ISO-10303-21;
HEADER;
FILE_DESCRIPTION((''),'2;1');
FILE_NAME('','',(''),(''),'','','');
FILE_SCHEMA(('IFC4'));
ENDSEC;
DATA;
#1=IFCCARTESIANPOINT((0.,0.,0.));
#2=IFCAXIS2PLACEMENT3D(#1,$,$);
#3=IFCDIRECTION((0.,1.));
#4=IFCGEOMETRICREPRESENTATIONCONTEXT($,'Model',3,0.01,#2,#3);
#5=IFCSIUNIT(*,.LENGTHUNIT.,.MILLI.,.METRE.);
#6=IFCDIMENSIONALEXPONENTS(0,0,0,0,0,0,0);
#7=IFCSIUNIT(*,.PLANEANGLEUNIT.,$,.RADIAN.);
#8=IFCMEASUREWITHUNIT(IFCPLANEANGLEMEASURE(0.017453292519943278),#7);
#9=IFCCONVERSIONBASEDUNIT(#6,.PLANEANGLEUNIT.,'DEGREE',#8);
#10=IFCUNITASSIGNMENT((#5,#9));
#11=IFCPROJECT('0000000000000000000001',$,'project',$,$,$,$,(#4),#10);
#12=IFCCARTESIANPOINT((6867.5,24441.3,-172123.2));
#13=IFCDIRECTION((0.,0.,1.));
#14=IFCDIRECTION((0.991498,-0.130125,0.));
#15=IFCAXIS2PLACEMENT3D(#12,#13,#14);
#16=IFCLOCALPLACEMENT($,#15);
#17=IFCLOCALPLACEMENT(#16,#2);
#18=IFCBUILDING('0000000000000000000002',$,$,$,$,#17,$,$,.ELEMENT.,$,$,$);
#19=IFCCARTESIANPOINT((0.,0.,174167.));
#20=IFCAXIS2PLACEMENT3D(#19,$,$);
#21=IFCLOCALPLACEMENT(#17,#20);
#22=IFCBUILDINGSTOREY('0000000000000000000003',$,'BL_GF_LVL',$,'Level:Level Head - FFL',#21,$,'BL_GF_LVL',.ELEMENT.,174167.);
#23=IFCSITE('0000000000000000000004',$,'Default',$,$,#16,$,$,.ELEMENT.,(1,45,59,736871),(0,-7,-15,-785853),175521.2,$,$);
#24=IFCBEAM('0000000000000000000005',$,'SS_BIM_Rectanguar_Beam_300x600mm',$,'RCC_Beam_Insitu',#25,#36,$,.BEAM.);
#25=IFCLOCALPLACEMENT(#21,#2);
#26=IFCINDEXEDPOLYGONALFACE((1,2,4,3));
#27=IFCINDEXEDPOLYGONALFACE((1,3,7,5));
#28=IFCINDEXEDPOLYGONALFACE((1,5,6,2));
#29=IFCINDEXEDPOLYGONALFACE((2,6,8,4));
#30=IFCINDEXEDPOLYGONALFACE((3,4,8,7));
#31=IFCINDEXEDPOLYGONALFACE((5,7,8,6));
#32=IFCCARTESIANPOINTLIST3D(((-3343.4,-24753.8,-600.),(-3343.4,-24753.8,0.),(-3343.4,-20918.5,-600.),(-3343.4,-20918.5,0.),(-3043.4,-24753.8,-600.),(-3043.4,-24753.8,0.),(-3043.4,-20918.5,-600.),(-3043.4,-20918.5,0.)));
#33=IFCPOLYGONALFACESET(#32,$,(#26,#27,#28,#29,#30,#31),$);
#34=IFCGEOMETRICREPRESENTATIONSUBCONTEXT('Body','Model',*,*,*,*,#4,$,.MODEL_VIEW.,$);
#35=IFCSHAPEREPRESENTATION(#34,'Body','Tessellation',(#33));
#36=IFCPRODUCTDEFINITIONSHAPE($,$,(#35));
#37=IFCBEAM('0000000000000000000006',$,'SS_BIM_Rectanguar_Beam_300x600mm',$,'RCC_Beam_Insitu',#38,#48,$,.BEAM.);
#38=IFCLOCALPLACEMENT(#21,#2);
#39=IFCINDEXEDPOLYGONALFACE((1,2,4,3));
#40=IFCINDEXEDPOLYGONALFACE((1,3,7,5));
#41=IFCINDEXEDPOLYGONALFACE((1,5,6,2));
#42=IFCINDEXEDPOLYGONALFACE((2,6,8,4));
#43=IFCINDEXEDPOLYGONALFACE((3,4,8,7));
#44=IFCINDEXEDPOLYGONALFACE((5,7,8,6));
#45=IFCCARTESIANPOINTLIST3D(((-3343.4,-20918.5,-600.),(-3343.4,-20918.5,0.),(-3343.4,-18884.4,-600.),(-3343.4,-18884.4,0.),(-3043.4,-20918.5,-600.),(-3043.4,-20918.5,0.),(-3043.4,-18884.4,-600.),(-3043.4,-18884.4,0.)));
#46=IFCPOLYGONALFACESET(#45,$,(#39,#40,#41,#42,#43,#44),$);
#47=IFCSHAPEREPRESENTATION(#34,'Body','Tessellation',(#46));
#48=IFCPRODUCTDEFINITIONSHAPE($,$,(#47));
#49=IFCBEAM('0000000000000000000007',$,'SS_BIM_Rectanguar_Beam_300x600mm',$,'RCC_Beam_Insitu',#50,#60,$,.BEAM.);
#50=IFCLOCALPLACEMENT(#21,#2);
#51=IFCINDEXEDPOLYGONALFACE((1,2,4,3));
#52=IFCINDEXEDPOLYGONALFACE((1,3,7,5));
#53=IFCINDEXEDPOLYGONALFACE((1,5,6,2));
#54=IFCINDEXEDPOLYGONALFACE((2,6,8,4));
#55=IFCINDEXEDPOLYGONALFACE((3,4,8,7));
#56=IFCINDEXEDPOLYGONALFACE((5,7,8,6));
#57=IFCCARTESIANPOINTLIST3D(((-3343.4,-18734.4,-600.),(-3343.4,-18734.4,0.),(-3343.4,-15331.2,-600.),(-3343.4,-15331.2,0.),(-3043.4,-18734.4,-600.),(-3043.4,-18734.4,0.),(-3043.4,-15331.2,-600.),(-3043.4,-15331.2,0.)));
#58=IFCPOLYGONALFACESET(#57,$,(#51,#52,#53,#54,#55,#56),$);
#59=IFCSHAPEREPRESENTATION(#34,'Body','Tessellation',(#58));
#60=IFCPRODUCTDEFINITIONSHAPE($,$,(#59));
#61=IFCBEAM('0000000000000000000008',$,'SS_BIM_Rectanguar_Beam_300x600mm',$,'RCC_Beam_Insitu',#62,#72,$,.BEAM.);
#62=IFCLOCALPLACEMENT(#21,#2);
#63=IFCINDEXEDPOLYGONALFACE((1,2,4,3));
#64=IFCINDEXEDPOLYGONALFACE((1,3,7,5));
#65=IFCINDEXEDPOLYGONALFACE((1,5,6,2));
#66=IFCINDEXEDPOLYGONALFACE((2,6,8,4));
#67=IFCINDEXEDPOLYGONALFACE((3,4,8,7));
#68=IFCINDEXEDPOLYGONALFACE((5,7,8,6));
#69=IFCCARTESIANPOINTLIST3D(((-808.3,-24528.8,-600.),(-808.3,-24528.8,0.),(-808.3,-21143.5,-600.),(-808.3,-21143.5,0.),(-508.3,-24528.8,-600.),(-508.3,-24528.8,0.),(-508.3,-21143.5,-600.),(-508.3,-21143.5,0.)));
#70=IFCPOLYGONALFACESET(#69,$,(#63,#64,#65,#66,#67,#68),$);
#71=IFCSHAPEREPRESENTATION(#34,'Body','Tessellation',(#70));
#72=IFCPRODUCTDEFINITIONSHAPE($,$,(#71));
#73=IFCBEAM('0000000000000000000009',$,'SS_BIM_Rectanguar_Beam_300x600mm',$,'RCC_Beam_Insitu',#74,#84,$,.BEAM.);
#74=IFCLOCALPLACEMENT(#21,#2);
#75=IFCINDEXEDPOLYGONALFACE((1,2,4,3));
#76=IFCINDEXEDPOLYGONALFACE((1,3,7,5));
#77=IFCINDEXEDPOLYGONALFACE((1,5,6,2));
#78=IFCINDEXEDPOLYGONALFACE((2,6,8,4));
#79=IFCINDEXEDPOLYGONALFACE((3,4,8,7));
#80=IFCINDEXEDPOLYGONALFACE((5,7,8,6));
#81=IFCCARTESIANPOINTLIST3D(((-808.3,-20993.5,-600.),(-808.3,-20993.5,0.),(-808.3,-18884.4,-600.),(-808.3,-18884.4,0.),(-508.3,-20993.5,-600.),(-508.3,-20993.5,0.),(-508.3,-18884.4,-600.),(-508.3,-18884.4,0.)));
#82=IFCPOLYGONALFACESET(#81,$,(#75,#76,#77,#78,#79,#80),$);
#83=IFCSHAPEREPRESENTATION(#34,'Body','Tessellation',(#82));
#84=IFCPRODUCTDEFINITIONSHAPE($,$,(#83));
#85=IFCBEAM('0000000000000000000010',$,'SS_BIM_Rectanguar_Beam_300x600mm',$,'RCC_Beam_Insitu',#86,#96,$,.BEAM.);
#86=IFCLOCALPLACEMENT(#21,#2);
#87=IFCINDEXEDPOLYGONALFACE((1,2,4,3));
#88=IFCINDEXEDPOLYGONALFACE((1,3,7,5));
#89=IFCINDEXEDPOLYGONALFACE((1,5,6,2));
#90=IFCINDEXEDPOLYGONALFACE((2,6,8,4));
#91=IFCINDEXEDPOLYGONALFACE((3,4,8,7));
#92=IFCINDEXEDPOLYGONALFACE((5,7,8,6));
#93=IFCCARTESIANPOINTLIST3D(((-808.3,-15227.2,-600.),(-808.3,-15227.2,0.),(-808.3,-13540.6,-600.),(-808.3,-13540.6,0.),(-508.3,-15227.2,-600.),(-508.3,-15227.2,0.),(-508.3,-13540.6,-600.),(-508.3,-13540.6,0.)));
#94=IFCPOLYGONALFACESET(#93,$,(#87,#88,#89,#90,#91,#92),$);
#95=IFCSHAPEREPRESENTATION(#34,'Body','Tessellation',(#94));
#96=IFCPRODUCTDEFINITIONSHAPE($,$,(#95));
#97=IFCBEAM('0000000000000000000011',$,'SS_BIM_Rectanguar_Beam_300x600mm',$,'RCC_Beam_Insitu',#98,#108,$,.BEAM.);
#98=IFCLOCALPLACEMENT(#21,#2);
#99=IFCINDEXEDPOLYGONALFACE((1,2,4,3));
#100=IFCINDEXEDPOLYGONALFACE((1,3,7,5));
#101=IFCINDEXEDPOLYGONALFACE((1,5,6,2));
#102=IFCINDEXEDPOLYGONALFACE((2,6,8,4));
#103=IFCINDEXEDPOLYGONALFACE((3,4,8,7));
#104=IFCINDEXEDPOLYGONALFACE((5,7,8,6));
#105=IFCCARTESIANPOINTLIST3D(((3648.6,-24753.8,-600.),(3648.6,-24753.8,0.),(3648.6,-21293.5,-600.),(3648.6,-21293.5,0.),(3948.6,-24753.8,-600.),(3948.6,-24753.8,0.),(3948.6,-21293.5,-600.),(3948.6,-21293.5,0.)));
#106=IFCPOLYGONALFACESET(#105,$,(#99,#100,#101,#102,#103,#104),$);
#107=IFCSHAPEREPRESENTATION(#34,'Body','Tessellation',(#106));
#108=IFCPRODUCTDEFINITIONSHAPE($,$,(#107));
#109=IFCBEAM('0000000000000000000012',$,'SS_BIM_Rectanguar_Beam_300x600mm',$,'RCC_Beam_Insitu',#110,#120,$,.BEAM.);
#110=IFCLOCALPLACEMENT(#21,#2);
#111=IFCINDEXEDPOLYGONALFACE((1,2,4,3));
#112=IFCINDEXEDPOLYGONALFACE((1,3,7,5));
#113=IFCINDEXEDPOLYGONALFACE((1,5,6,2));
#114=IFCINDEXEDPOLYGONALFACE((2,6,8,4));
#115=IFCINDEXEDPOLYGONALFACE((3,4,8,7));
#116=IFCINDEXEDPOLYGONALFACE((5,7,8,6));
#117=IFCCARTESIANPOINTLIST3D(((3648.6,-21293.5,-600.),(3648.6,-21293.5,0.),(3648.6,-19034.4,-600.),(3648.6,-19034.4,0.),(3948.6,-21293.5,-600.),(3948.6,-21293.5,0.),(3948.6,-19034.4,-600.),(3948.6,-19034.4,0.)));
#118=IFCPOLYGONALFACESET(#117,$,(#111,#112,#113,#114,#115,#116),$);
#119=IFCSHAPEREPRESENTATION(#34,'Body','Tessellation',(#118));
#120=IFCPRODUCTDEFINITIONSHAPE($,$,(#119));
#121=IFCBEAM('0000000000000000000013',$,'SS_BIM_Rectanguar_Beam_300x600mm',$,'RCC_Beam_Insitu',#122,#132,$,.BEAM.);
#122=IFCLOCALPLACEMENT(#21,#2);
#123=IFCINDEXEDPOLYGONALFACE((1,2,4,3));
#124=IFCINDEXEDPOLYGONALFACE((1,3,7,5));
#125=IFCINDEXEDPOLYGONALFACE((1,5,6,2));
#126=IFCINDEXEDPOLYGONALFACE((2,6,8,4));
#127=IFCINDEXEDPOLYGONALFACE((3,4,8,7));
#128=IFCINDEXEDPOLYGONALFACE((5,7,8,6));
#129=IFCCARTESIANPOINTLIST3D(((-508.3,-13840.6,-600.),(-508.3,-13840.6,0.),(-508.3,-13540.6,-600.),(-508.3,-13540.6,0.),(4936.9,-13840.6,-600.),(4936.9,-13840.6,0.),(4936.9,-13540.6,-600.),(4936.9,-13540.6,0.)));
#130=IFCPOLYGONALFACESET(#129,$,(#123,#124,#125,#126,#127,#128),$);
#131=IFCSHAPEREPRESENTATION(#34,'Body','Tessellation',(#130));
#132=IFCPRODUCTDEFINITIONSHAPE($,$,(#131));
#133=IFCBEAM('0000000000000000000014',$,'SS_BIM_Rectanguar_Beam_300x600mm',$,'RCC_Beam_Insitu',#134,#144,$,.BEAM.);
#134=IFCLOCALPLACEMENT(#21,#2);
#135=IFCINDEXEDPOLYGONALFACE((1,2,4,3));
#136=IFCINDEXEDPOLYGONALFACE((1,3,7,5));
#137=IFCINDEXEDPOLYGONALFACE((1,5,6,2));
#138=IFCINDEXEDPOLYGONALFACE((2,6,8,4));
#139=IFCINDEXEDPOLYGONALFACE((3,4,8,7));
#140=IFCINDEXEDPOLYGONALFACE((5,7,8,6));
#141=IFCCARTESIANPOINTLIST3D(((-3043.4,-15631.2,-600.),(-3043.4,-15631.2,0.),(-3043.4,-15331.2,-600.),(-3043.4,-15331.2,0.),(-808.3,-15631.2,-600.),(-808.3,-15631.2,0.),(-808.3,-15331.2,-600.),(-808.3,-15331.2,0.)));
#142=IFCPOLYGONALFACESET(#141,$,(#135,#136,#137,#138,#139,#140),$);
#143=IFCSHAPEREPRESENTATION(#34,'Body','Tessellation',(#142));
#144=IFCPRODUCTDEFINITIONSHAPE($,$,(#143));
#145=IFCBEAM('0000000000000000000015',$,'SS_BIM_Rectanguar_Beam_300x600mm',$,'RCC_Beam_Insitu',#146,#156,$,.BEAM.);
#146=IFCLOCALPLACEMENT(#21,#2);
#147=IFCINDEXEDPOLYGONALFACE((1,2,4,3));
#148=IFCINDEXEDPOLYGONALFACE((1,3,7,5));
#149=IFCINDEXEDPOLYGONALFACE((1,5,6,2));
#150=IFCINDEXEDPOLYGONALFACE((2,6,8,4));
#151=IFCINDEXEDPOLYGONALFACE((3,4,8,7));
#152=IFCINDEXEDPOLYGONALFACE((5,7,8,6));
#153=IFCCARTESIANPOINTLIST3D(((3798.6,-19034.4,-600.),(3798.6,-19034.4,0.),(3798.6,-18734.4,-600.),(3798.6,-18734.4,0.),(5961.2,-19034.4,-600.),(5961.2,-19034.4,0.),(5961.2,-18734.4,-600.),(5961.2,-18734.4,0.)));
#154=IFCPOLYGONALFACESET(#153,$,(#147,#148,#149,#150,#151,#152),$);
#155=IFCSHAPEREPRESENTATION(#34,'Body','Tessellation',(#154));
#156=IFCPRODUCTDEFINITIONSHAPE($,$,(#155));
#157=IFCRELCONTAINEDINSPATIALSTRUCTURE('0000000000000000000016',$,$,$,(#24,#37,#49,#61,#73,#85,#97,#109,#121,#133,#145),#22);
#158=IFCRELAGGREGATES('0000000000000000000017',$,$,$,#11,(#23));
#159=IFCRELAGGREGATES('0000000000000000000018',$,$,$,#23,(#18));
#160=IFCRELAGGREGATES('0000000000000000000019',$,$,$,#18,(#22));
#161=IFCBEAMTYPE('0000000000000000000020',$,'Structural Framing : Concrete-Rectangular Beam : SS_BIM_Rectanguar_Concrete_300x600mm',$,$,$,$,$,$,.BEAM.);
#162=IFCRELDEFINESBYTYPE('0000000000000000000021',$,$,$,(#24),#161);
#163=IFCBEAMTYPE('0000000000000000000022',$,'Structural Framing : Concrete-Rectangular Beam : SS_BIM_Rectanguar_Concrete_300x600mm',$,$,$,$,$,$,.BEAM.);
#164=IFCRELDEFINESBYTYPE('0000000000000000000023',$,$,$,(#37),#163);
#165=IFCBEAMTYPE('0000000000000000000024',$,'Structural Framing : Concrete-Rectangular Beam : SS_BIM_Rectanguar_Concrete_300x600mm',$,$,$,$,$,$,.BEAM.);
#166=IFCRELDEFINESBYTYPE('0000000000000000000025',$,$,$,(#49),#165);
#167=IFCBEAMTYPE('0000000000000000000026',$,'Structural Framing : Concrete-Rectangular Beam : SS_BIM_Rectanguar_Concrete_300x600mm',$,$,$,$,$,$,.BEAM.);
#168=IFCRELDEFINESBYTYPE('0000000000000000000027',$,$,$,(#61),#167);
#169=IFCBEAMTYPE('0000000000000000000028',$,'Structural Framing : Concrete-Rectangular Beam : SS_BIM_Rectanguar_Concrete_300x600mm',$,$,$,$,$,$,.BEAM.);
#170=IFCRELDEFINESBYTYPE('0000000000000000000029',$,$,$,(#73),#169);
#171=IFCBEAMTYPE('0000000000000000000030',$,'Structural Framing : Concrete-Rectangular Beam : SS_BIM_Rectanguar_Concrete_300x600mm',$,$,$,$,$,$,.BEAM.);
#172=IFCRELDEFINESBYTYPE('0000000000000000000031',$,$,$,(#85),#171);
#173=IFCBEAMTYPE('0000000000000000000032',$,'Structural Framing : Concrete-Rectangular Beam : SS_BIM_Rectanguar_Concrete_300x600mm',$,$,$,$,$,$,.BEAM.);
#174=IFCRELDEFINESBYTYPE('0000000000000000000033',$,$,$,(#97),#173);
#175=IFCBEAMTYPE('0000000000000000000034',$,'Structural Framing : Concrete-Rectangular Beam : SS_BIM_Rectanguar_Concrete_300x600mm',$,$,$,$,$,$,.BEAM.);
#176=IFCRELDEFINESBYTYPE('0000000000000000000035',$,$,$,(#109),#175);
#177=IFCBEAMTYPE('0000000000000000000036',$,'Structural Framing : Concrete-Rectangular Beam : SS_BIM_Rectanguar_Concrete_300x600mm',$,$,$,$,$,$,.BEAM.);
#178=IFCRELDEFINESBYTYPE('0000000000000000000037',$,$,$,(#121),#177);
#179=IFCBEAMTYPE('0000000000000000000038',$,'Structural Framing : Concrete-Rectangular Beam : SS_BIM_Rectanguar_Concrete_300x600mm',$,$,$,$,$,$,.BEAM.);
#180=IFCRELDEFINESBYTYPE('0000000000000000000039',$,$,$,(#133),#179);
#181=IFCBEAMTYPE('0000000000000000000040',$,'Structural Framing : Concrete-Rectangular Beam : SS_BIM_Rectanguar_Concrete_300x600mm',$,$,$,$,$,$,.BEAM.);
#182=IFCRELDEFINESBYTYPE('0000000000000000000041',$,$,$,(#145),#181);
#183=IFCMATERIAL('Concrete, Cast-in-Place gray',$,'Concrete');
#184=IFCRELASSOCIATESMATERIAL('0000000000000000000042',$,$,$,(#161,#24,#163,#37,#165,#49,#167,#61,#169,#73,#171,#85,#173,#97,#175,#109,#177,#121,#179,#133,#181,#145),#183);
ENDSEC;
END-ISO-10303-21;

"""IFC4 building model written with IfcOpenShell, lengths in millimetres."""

from ifc_helpers import new_model, entity, si_unit, converted_unit, direction, frame, origin, place, context, subcontext, project, spatial, indexed_curve, outline, extrude, source, transform, mapped, material, type_object, type_shapes, element, save


model = new_model("IFC4")

# Units and contexts
model_context = context("Model", 3, precision=0.01, world=origin(), true_north=direction((0.0, 1.0)))
body_context = subcontext(model_context, "Body", "Model", "MODEL_VIEW")
ifc_project = project(units=[si_unit("LENGTHUNIT", "METRE", prefix="MILLI"), converted_unit("PLANEANGLEUNIT", "DEGREE", entity("IfcPlaneAngleMeasure", 0.017453292519943278), si_unit("PLANEANGLEUNIT", "RADIAN"), dimensions=[0, 0, 0, 0, 0, 0, 0])], contexts=[model_context])

# Site, building, storey
site_placement = place(None, frame((6867.5, 24441.3, -172123.2), z_axis=(0.0, 0.0, 1.0), x_axis=(0.991498, -0.130125, 0.0)))
site = spatial("IfcSite", under=ifc_project, at=site_placement, Name="Default", CompositionType="ELEMENT", RefLatitude=(1, 45, 59, 736871), RefLongitude=(0, -7, -15, -785853), RefElevation=175521.2)
building_placement = place(site_placement, origin())
building = spatial("IfcBuilding", under=site, at=building_placement, CompositionType="ELEMENT")
storey_placement = place(building_placement, frame((0.0, 0.0, 174167.0)))
storey = spatial("IfcBuildingStorey", under=building, at=storey_placement, Name="BL_GF_LVL", ObjectType="Level:Level Head - FFL", LongName="BL_GF_LVL", CompositionType="ELEMENT", Elevation=174167.0)

# Shared definitions
ifc_material_1 = material(Name="Concrete, Cast-in-Place gray", Category="Concrete")

# Beams
beam_type_1 = type_object("IfcBeamType", Name="Structural Framing : Concrete-Rectangular Beam : SS_BIM_Rectanguar_Concrete_300x600mm", PredefinedType="BEAM", material=ifc_material_1)
shared_shape_1 = source(origin(), body_context, "Body", "SweptSolid", [
    extrude(outline(indexed_curve([(-150.0, -300.0), (150.0, -300.0), (150.0, 300.0), (-150.0, 300.0), (-150.0, -300.0)], self_intersect=False)), frame((-3193.4, -24753.8, 173867.0), z_axis=(0.0, 1.0, 0.0), x_axis=(-1.0, 0.0, 0.0)), (0.0, 0.0, 1.0), 3835.3),
])
type_shapes(beam_type_1, [shared_shape_1])
beam_1_placement = place(storey_placement, frame((0.0, 0.0, -174167.0)))
element("IfcBeam", 1, at=beam_1_placement, inside=storey, type_object=beam_type_1, material=ifc_material_1, Name="SS_BIM_Rectanguar_Beam_300x600mm", ObjectType="RCC_Beam_Insitu", PredefinedType="BEAM", context=body_context, shape_type="MappedRepresentation", body=[
    mapped(shared_shape_1, transform((0.0, 0.0, 0.0), scale=1.0)),
])
beam_type_2 = type_object("IfcBeamType", Name="Structural Framing : Concrete-Rectangular Beam : SS_BIM_Rectanguar_Concrete_300x600mm", PredefinedType="BEAM", material=ifc_material_1)
shared_shape_2 = source(origin(), body_context, "Body", "SweptSolid", [
    extrude(outline(indexed_curve([(-150.0, -300.0), (150.0, -300.0), (150.0, 300.0), (-150.0, 300.0), (-150.0, -300.0)], self_intersect=False)), frame((-3193.4, -20918.5, 173867.0), z_axis=(0.0, 1.0, 0.0), x_axis=(-1.0, 0.0, 0.0)), (0.0, 0.0, 1.0), 2034.1),
])
type_shapes(beam_type_2, [shared_shape_2])
beam_2_placement = place(storey_placement, frame((0.0, 0.0, -174167.0)))
element("IfcBeam", 2, at=beam_2_placement, inside=storey, type_object=beam_type_2, material=ifc_material_1, Name="SS_BIM_Rectanguar_Beam_300x600mm", ObjectType="RCC_Beam_Insitu", PredefinedType="BEAM", context=body_context, shape_type="MappedRepresentation", body=[
    mapped(shared_shape_2, transform((0.0, 0.0, 0.0), scale=1.0)),
])
beam_type_3 = type_object("IfcBeamType", Name="Structural Framing : Concrete-Rectangular Beam : SS_BIM_Rectanguar_Concrete_300x600mm", PredefinedType="BEAM", material=ifc_material_1)
shared_shape_3 = source(origin(), body_context, "Body", "SweptSolid", [
    extrude(outline(indexed_curve([(-150.0, -300.0), (150.0, -300.0), (150.0, 300.0), (-150.0, 300.0), (-150.0, -300.0)], self_intersect=False)), frame((-3193.4, -18734.4, 173867.0), z_axis=(0.0, 1.0, 0.0), x_axis=(-1.0, 0.0, 0.0)), (0.0, 0.0, 1.0), 3403.2),
])
type_shapes(beam_type_3, [shared_shape_3])
beam_3_placement = place(storey_placement, frame((0.0, 0.0, -174167.0)))
element("IfcBeam", 3, at=beam_3_placement, inside=storey, type_object=beam_type_3, material=ifc_material_1, Name="SS_BIM_Rectanguar_Beam_300x600mm", ObjectType="RCC_Beam_Insitu", PredefinedType="BEAM", context=body_context, shape_type="MappedRepresentation", body=[
    mapped(shared_shape_3, transform((0.0, 0.0, 0.0), scale=1.0)),
])
beam_type_4 = type_object("IfcBeamType", Name="Structural Framing : Concrete-Rectangular Beam : SS_BIM_Rectanguar_Concrete_300x600mm", PredefinedType="BEAM", material=ifc_material_1)
shared_shape_4 = source(origin(), body_context, "Body", "SweptSolid", [
    extrude(outline(indexed_curve([(-150.0, -300.0), (150.0, -300.0), (150.0, 300.0), (-150.0, 300.0), (-150.0, -300.0)], self_intersect=False)), frame((-658.3, -24528.8, 173867.0), z_axis=(0.0, 1.0, 0.0), x_axis=(-1.0, 0.0, 0.0)), (0.0, 0.0, 1.0), 3385.3),
])
type_shapes(beam_type_4, [shared_shape_4])
beam_4_placement = place(storey_placement, frame((0.0, 0.0, -174167.0)))
element("IfcBeam", 4, at=beam_4_placement, inside=storey, type_object=beam_type_4, material=ifc_material_1, Name="SS_BIM_Rectanguar_Beam_300x600mm", ObjectType="RCC_Beam_Insitu", PredefinedType="BEAM", context=body_context, shape_type="MappedRepresentation", body=[
    mapped(shared_shape_4, transform((0.0, 0.0, 0.0), scale=1.0)),
])
beam_type_5 = type_object("IfcBeamType", Name="Structural Framing : Concrete-Rectangular Beam : SS_BIM_Rectanguar_Concrete_300x600mm", PredefinedType="BEAM", material=ifc_material_1)
shared_shape_5 = source(origin(), body_context, "Body", "SweptSolid", [
    extrude(outline(indexed_curve([(-150.0, -300.0), (150.0, -300.0), (150.0, 300.0), (-150.0, 300.0), (-150.0, -300.0)], self_intersect=False)), frame((-658.3, -20993.5, 173867.0), z_axis=(0.0, 1.0, 0.0), x_axis=(-1.0, 0.0, 0.0)), (0.0, 0.0, 1.0), 2109.1),
])
type_shapes(beam_type_5, [shared_shape_5])
beam_5_placement = place(storey_placement, frame((0.0, 0.0, -174167.0)))
element("IfcBeam", 5, at=beam_5_placement, inside=storey, type_object=beam_type_5, material=ifc_material_1, Name="SS_BIM_Rectanguar_Beam_300x600mm", ObjectType="RCC_Beam_Insitu", PredefinedType="BEAM", context=body_context, shape_type="MappedRepresentation", body=[
    mapped(shared_shape_5, transform((0.0, 0.0, 0.0), scale=1.0)),
])
beam_type_6 = type_object("IfcBeamType", Name="Structural Framing : Concrete-Rectangular Beam : SS_BIM_Rectanguar_Concrete_300x600mm", PredefinedType="BEAM", material=ifc_material_1)
shared_shape_6 = source(origin(), body_context, "Body", "SweptSolid", [
    extrude(outline(indexed_curve([(-150.0, -300.0), (150.0, -300.0), (150.0, 300.0), (-150.0, 300.0), (-150.0, -300.0)], self_intersect=False)), frame((-658.3, -15227.2, 173867.0), z_axis=(0.0, 1.0, 0.0), x_axis=(-1.0, 0.0, 0.0)), (0.0, 0.0, 1.0), 1686.5),
])
type_shapes(beam_type_6, [shared_shape_6])
beam_6_placement = place(storey_placement, frame((0.0, 0.0, -174167.0)))
element("IfcBeam", 6, at=beam_6_placement, inside=storey, type_object=beam_type_6, material=ifc_material_1, Name="SS_BIM_Rectanguar_Beam_300x600mm", ObjectType="RCC_Beam_Insitu", PredefinedType="BEAM", context=body_context, shape_type="MappedRepresentation", body=[
    mapped(shared_shape_6, transform((0.0, 0.0, 0.0), scale=1.0)),
])
beam_type_7 = type_object("IfcBeamType", Name="Structural Framing : Concrete-Rectangular Beam : SS_BIM_Rectanguar_Concrete_300x600mm", PredefinedType="BEAM", material=ifc_material_1)
shared_shape_7 = source(origin(), body_context, "Body", "SweptSolid", [
    extrude(outline(indexed_curve([(-150.0, -300.0), (150.0, -300.0), (150.0, 300.0), (-150.0, 300.0), (-150.0, -300.0)], self_intersect=False)), frame((3798.6, -24753.8, 173867.0), z_axis=(0.0, 1.0, 0.0), x_axis=(-1.0, 0.0, 0.0)), (0.0, 0.0, 1.0), 3460.3),
])
type_shapes(beam_type_7, [shared_shape_7])
beam_7_placement = place(storey_placement, frame((0.0, 0.0, -174167.0)))
element("IfcBeam", 7, at=beam_7_placement, inside=storey, type_object=beam_type_7, material=ifc_material_1, Name="SS_BIM_Rectanguar_Beam_300x600mm", ObjectType="RCC_Beam_Insitu", PredefinedType="BEAM", context=body_context, shape_type="MappedRepresentation", body=[
    mapped(shared_shape_7, transform((0.0, 0.0, 0.0), scale=1.0)),
])
beam_type_8 = type_object("IfcBeamType", Name="Structural Framing : Concrete-Rectangular Beam : SS_BIM_Rectanguar_Concrete_300x600mm", PredefinedType="BEAM", material=ifc_material_1)
shared_shape_8 = source(origin(), body_context, "Body", "SweptSolid", [
    extrude(outline(indexed_curve([(-150.0, -300.0), (150.0, -300.0), (150.0, 300.0), (-150.0, 300.0), (-150.0, -300.0)], self_intersect=False)), frame((3798.6, -21293.5, 173867.0), z_axis=(0.0, 1.0, 0.0), x_axis=(-1.0, 0.0, 0.0)), (0.0, 0.0, 1.0), 2259.1),
])
type_shapes(beam_type_8, [shared_shape_8])
beam_8_placement = place(storey_placement, frame((0.0, 0.0, -174167.0)))
element("IfcBeam", 8, at=beam_8_placement, inside=storey, type_object=beam_type_8, material=ifc_material_1, Name="SS_BIM_Rectanguar_Beam_300x600mm", ObjectType="RCC_Beam_Insitu", PredefinedType="BEAM", context=body_context, shape_type="MappedRepresentation", body=[
    mapped(shared_shape_8, transform((0.0, 0.0, 0.0), scale=1.0)),
])
beam_type_9 = type_object("IfcBeamType", Name="Structural Framing : Concrete-Rectangular Beam : SS_BIM_Rectanguar_Concrete_300x600mm", PredefinedType="BEAM", material=ifc_material_1)
shared_shape_9 = source(origin(), body_context, "Body", "SweptSolid", [
    extrude(outline(indexed_curve([(-300.0, -150.0), (300.0, -150.0), (300.0, 150.0), (-300.0, 150.0), (-300.0, -150.0)], self_intersect=False)), frame((-508.3, -13690.6, 173867.0), z_axis=(1.0, 0.0, 0.0), x_axis=(0.0, 0.0, -1.0)), (0.0, 0.0, 1.0), 5445.2),
])
type_shapes(beam_type_9, [shared_shape_9])
beam_9_placement = place(storey_placement, frame((0.0, 0.0, -174167.0)))
element("IfcBeam", 9, at=beam_9_placement, inside=storey, type_object=beam_type_9, material=ifc_material_1, Name="SS_BIM_Rectanguar_Beam_300x600mm", ObjectType="RCC_Beam_Insitu", PredefinedType="BEAM", context=body_context, shape_type="MappedRepresentation", body=[
    mapped(shared_shape_9, transform((0.0, 0.0, 0.0), scale=1.0)),
])
beam_type_10 = type_object("IfcBeamType", Name="Structural Framing : Concrete-Rectangular Beam : SS_BIM_Rectanguar_Concrete_300x600mm", PredefinedType="BEAM", material=ifc_material_1)
shared_shape_10 = source(origin(), body_context, "Body", "SweptSolid", [
    extrude(outline(indexed_curve([(-300.0, -150.0), (300.0, -150.0), (300.0, 150.0), (-300.0, 150.0), (-300.0, -150.0)], self_intersect=False)), frame((-3043.4, -15481.2, 173867.0), z_axis=(1.0, 0.0, 0.0), x_axis=(0.0, 0.0, -1.0)), (0.0, 0.0, 1.0), 2235.1),
])
type_shapes(beam_type_10, [shared_shape_10])
beam_10_placement = place(storey_placement, frame((0.0, 0.0, -174167.0)))
element("IfcBeam", 10, at=beam_10_placement, inside=storey, type_object=beam_type_10, material=ifc_material_1, Name="SS_BIM_Rectanguar_Beam_300x600mm", ObjectType="RCC_Beam_Insitu", PredefinedType="BEAM", context=body_context, shape_type="MappedRepresentation", body=[
    mapped(shared_shape_10, transform((0.0, 0.0, 0.0), scale=1.0)),
])
beam_type_11 = type_object("IfcBeamType", Name="Structural Framing : Concrete-Rectangular Beam : SS_BIM_Rectanguar_Concrete_300x600mm", PredefinedType="BEAM", material=ifc_material_1)
shared_shape_11 = source(origin(), body_context, "Body", "SweptSolid", [
    extrude(outline(indexed_curve([(-300.0, -150.0), (300.0, -150.0), (300.0, 150.0), (-300.0, 150.0), (-300.0, -150.0)], self_intersect=False)), frame((3798.6, -18884.4, 173867.0), z_axis=(1.0, 0.0, 0.0), x_axis=(0.0, 0.0, -1.0)), (0.0, 0.0, 1.0), 2162.6),
])
type_shapes(beam_type_11, [shared_shape_11])
beam_11_placement = place(storey_placement, frame((0.0, 0.0, -174167.0)))
element("IfcBeam", 11, at=beam_11_placement, inside=storey, type_object=beam_type_11, material=ifc_material_1, Name="SS_BIM_Rectanguar_Beam_300x600mm", ObjectType="RCC_Beam_Insitu", PredefinedType="BEAM", context=body_context, shape_type="MappedRepresentation", body=[
    mapped(shared_shape_11, transform((0.0, 0.0, 0.0), scale=1.0)),
])

save(model, "model.ifc")
